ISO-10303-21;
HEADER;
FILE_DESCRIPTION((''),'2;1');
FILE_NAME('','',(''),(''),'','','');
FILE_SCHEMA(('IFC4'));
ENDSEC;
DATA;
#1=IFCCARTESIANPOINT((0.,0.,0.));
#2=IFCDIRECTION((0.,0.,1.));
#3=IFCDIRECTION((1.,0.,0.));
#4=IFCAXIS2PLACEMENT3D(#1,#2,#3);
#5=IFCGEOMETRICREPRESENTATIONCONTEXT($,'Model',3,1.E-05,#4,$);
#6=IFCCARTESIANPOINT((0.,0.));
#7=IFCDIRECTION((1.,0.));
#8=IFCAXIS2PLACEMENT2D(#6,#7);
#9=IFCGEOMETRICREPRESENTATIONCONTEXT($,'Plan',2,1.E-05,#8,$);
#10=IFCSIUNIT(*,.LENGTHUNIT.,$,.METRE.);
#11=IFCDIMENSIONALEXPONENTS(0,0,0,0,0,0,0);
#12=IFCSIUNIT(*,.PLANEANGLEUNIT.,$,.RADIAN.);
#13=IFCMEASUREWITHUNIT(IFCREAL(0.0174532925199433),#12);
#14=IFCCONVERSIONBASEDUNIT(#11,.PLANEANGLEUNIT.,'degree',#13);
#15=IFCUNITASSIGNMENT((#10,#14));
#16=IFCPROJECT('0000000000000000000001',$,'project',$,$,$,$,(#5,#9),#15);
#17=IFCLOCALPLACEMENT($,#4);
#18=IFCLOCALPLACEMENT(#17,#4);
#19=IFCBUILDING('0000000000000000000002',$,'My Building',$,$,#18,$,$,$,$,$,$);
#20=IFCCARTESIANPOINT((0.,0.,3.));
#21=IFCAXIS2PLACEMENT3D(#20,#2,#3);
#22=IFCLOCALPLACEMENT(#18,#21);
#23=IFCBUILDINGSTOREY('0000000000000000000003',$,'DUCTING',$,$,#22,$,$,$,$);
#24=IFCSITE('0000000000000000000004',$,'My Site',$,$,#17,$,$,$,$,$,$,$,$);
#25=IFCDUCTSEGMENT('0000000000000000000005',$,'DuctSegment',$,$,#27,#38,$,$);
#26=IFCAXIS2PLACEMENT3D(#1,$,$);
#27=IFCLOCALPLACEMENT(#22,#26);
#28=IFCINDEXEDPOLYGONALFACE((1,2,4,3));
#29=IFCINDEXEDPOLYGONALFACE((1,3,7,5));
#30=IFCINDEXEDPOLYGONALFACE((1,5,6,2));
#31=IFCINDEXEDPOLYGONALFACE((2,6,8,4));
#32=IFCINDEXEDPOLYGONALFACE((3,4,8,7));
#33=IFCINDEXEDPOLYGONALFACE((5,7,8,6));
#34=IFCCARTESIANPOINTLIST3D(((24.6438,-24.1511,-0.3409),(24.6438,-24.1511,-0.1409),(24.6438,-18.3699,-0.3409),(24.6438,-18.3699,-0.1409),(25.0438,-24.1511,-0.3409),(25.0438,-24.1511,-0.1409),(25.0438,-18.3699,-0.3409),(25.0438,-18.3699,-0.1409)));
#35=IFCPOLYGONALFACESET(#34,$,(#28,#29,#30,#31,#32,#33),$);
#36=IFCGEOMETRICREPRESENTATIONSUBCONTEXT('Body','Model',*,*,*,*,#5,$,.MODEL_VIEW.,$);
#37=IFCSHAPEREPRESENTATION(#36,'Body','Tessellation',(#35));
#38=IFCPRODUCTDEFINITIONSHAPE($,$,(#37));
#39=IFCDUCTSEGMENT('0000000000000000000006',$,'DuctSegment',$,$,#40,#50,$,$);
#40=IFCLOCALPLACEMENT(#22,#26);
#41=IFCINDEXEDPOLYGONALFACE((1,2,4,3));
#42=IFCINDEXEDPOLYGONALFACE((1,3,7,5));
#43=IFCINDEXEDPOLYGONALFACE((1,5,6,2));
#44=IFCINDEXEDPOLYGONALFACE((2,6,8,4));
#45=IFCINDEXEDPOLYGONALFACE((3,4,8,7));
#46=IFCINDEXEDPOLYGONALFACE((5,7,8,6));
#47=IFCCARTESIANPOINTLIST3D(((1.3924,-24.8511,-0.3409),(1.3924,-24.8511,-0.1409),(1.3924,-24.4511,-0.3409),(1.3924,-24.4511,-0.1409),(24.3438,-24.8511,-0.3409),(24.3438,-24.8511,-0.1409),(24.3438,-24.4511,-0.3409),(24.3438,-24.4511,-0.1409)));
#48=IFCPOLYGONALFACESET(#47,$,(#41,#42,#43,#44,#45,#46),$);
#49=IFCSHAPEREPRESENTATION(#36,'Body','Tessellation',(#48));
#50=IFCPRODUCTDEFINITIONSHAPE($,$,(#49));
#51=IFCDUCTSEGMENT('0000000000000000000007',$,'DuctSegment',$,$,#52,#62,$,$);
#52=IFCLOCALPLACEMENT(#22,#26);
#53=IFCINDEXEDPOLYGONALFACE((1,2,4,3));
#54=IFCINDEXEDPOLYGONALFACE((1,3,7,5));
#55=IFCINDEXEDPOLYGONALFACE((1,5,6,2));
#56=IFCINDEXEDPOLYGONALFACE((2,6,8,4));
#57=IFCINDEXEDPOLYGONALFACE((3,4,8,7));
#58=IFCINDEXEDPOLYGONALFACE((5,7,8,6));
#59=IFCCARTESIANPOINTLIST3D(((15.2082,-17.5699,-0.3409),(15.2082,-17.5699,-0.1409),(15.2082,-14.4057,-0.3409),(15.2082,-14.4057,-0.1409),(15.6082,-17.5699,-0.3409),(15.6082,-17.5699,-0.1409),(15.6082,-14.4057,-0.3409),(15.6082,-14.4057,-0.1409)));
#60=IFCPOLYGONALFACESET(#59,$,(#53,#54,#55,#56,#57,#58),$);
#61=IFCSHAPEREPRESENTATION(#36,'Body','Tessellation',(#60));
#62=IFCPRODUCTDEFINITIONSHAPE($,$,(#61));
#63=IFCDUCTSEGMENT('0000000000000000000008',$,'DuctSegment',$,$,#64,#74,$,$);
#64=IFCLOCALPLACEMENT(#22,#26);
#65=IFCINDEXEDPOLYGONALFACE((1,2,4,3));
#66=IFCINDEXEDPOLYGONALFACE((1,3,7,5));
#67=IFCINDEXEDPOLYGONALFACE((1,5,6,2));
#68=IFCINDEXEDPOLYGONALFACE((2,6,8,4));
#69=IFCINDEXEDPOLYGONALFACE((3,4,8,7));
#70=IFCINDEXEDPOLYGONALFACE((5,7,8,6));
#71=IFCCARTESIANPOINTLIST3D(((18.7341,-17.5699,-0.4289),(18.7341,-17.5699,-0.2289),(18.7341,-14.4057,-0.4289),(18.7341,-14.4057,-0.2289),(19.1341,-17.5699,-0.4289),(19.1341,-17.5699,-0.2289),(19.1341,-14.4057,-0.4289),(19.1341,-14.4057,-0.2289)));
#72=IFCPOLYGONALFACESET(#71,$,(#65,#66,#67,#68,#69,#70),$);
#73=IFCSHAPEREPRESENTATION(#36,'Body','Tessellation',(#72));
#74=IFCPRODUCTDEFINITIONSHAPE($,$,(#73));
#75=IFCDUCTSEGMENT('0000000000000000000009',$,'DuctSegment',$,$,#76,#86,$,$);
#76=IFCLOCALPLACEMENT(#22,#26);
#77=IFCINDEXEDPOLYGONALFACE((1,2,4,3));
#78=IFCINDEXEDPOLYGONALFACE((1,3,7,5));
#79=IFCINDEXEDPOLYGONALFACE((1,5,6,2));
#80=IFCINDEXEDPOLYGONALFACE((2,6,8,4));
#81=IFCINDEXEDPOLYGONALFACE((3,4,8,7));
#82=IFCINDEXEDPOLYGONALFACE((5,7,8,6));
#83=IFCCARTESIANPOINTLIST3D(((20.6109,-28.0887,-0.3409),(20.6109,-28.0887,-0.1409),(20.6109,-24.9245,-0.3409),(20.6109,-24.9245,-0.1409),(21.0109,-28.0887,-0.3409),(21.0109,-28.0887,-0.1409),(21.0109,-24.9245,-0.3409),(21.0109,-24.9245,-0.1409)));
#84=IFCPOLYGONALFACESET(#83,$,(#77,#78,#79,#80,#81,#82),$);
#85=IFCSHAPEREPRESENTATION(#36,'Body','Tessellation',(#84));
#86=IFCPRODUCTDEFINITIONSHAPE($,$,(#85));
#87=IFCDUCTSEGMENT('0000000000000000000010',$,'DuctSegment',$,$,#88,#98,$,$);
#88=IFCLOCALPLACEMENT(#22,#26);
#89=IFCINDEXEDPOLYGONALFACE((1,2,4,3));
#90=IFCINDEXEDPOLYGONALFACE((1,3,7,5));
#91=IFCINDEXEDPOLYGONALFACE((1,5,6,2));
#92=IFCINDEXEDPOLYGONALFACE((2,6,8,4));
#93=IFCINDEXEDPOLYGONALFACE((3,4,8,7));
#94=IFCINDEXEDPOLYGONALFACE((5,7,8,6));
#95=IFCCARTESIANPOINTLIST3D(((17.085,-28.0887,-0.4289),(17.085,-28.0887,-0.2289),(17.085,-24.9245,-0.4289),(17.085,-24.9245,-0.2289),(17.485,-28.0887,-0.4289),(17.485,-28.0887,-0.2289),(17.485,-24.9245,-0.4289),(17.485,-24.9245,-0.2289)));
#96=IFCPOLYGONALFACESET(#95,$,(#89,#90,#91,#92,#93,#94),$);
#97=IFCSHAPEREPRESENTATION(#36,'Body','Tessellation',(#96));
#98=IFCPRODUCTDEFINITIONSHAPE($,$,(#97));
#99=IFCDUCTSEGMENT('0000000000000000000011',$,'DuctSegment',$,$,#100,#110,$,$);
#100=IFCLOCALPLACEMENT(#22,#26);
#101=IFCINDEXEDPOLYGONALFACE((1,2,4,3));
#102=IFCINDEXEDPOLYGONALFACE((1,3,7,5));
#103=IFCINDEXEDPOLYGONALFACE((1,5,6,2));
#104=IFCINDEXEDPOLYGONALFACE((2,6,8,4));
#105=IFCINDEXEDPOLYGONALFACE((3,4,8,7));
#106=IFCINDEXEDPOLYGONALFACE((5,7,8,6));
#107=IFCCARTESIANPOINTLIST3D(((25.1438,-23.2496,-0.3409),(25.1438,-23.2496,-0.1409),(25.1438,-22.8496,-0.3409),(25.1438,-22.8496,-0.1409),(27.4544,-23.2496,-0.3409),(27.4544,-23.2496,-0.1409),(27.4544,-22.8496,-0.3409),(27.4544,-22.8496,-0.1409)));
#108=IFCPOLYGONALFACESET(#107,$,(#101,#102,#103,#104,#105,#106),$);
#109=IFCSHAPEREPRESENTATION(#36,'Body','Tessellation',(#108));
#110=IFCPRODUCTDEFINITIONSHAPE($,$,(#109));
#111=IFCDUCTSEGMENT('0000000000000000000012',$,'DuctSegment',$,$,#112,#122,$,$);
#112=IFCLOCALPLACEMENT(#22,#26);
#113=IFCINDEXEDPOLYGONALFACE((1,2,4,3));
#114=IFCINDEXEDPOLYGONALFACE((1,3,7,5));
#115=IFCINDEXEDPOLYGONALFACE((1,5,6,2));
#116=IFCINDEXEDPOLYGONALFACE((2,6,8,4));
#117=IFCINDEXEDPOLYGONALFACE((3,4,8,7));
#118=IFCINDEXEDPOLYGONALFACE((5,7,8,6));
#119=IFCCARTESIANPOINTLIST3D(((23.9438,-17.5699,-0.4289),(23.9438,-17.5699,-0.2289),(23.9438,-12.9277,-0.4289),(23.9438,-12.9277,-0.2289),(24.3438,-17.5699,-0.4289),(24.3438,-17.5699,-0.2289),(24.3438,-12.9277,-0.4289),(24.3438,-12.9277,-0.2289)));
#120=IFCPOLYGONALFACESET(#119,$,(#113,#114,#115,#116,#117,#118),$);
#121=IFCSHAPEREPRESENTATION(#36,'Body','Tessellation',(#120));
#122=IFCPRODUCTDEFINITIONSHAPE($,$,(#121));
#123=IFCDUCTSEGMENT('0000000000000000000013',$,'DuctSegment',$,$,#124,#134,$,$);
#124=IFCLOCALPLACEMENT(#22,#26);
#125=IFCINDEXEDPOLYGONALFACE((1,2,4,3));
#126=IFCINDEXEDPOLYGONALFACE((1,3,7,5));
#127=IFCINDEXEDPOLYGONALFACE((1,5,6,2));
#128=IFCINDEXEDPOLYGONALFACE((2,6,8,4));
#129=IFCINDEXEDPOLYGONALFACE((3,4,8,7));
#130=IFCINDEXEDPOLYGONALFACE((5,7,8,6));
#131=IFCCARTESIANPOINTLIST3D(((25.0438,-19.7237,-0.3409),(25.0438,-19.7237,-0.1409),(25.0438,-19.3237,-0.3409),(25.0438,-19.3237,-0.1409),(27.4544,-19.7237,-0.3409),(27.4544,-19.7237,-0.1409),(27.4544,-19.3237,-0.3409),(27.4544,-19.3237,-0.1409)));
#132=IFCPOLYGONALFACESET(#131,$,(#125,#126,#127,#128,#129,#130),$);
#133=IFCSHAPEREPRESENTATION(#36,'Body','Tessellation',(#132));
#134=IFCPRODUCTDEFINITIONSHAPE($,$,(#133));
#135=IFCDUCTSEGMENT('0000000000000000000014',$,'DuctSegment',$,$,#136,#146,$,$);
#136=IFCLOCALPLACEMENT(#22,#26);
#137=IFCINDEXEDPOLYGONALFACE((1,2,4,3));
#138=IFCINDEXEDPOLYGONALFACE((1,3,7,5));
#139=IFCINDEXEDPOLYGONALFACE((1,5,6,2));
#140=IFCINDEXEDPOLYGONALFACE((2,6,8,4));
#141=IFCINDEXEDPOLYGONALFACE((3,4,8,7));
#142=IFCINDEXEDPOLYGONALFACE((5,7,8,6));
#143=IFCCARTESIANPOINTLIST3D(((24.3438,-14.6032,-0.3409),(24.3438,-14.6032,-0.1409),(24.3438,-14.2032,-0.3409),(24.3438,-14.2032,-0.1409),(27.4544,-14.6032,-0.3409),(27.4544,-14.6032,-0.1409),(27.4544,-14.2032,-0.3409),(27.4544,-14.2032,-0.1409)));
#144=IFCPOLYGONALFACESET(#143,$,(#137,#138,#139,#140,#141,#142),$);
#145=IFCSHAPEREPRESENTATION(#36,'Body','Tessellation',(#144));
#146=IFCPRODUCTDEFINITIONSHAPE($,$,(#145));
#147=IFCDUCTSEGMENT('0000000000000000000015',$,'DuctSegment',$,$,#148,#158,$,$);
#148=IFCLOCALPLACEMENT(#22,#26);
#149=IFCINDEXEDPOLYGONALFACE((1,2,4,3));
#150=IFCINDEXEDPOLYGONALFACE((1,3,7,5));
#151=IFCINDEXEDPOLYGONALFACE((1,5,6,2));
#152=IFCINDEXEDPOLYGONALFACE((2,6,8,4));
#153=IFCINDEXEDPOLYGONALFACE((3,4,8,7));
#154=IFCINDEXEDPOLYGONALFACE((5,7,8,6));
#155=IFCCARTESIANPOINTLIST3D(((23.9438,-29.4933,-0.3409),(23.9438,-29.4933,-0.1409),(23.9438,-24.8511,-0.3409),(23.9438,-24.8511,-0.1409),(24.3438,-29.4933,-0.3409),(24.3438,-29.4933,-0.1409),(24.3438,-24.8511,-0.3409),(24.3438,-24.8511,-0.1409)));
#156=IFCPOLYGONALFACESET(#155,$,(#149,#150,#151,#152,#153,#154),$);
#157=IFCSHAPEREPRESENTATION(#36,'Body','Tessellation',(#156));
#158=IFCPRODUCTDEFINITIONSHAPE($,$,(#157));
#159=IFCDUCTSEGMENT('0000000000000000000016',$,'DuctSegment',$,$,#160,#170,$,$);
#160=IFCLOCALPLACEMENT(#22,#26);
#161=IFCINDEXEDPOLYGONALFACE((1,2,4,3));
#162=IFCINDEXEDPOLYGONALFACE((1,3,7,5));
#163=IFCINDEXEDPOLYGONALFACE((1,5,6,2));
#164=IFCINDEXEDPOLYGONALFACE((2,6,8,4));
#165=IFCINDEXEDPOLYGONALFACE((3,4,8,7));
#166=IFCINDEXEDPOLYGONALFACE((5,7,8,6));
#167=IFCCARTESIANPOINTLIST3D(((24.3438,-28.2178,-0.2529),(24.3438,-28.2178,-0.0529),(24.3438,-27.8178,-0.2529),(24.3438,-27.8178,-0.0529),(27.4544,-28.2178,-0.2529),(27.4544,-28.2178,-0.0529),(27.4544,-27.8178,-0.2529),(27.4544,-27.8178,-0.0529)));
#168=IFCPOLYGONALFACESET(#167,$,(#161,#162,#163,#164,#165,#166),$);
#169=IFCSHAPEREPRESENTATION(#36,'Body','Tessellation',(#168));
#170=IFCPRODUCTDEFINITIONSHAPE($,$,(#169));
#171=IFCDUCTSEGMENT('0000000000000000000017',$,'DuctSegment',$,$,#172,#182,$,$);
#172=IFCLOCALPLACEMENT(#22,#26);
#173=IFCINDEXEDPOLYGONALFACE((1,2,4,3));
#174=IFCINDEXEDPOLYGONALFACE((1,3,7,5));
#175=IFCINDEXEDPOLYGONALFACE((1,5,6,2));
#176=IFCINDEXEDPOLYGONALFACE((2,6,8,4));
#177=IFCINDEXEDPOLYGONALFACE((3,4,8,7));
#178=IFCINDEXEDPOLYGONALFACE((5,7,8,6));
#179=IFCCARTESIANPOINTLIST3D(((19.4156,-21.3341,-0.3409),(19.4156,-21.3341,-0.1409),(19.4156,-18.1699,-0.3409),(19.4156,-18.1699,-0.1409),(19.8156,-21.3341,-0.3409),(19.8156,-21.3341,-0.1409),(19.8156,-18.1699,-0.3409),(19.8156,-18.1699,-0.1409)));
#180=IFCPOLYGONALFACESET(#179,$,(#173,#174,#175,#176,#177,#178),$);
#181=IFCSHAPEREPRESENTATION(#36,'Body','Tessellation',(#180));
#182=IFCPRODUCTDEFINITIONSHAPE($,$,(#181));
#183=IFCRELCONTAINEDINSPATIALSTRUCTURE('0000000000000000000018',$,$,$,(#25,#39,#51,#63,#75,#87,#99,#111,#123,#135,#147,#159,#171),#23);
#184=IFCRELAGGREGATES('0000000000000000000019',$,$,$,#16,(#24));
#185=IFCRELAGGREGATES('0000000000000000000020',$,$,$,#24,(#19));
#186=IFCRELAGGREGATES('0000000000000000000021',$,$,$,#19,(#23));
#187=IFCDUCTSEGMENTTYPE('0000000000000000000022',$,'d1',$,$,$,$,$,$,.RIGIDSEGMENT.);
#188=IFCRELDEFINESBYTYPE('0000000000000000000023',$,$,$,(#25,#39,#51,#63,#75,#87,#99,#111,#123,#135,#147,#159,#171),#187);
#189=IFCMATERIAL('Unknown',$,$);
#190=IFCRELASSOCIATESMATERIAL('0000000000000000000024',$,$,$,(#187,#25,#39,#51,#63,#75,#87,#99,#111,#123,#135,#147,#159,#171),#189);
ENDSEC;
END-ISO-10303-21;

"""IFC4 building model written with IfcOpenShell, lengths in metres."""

from ifc_helpers import new_model, entity, si_unit, converted_unit, frame, origin_with_axes, origin_2d_with_axis, place, context, subcontext, project, spatial, rectangle, extrude, material, material_profile, profile_set, profile_usage, type_object, element, save


model = new_model("IFC4")

# Units and contexts
model_context = context("Model", 3, precision=1e-05, world=origin_with_axes())
plan_context = context("Plan", 2, precision=1e-05, world=origin_2d_with_axis())
body_context = subcontext(model_context, "Body", "Model", "MODEL_VIEW")
ifc_project = project(units=[si_unit("LENGTHUNIT", "METRE"), converted_unit("PLANEANGLEUNIT", "degree", entity("IfcReal", 0.0174532925199433), si_unit("PLANEANGLEUNIT", "RADIAN"), dimensions=[0, 0, 0, 0, 0, 0, 0])], contexts=[model_context, plan_context])

# Site, building, storey
site_placement = place(None, origin_with_axes())
site = spatial("IfcSite", under=ifc_project, at=site_placement, Name="My Site")
building_placement = place(site_placement, origin_with_axes())
building = spatial("IfcBuilding", under=site, at=building_placement, Name="My Building")
storey_placement = place(building_placement, frame((0.0, 0.0, 3.0), z_axis=(0.0, 0.0, 1.0), x_axis=(1.0, 0.0, 0.0)))
storey = spatial("IfcBuildingStorey", under=building, at=storey_placement, Name="DUCTING")

# Duct segments
ifc_material = material(Name="Unknown")
ifc_material_profile_1 = material_profile(ifc_material, rectangle(XDim=0.4, YDim=0.2))
ifc_profile_set_1 = profile_set([ifc_material_profile_1])
ifc_profile_usage_1 = profile_usage(ifc_profile_set_1, cardinal=5)
duct_segment_type = type_object("IfcDuctSegmentType", Name="d1", PredefinedType="RIGIDSEGMENT", material=ifc_profile_set_1)
duct_segment_1_placement = place(storey_placement, frame((24.8438, -18.3699, -0.2409), z_axis=(0.0, -1.0, 0.0), x_axis=(1.0, 0.0, 0.0)))
element("IfcDuctSegment", 1, at=duct_segment_1_placement, inside=storey, type_object=duct_segment_type, material=ifc_profile_usage_1, Name="DuctSegment", context=body_context, shape_type="SweptSolid", body=[
    extrude(rectangle(XDim=0.4, YDim=0.2), origin_with_axes(), (0.0, 0.0, 1.0), 5.7812),
])
ifc_profile_usage_2 = profile_usage(ifc_profile_set_1, cardinal=5)
duct_segment_2_placement = place(storey_placement, frame((24.3438, -24.6511, -0.2409), z_axis=(-1.0, 0.0, 0.0), x_axis=(0.0, -1.0, 0.0)))
element("IfcDuctSegment", 2, at=duct_segment_2_placement, inside=storey, type_object=duct_segment_type, material=ifc_profile_usage_2, Name="DuctSegment", context=body_context, shape_type="SweptSolid", body=[
    extrude(rectangle(XDim=0.4, YDim=0.2), origin_with_axes(), (0.0, 0.0, 1.0), 22.9514),
])
ifc_profile_usage_3 = profile_usage(ifc_profile_set_1, cardinal=5)
duct_segment_3_placement = place(storey_placement, frame((15.4082, -17.5699, -0.2409), z_axis=(0.0, 1.0, 0.0), x_axis=(-1.0, 0.0, 0.0)))
element("IfcDuctSegment", 3, at=duct_segment_3_placement, inside=storey, type_object=duct_segment_type, material=ifc_profile_usage_3, Name="DuctSegment", context=body_context, shape_type="SweptSolid", body=[
    extrude(rectangle(XDim=0.4, YDim=0.2), origin_with_axes(), (0.0, 0.0, 1.0), 3.1642),
])
ifc_profile_usage_4 = profile_usage(ifc_profile_set_1, cardinal=5)
duct_segment_4_placement = place(storey_placement, frame((18.9341, -17.5699, -0.3289), z_axis=(0.0, 1.0, 0.0), x_axis=(-1.0, 0.0, 0.0)))
element("IfcDuctSegment", 4, at=duct_segment_4_placement, inside=storey, type_object=duct_segment_type, material=ifc_profile_usage_4, Name="DuctSegment", context=body_context, shape_type="SweptSolid", body=[
    extrude(rectangle(XDim=0.4, YDim=0.2), origin_with_axes(), (0.0, 0.0, 1.0), 3.1642),
])
ifc_profile_usage_5 = profile_usage(ifc_profile_set_1, cardinal=5)
duct_segment_5_placement = place(storey_placement, frame((20.8109, -24.9245, -0.2409), z_axis=(0.0, -1.0, 0.0), x_axis=(1.0, 0.0, 0.0)))
element("IfcDuctSegment", 5, at=duct_segment_5_placement, inside=storey, type_object=duct_segment_type, material=ifc_profile_usage_5, Name="DuctSegment", context=body_context, shape_type="SweptSolid", body=[
    extrude(rectangle(XDim=0.4, YDim=0.2), origin_with_axes(), (0.0, 0.0, 1.0), 3.1642),
])
ifc_profile_usage_6 = profile_usage(ifc_profile_set_1, cardinal=5)
duct_segment_6_placement = place(storey_placement, frame((17.285, -24.9245, -0.3289), z_axis=(0.0, -1.0, 0.0), x_axis=(1.0, 0.0, 0.0)))
element("IfcDuctSegment", 6, at=duct_segment_6_placement, inside=storey, type_object=duct_segment_type, material=ifc_profile_usage_6, Name="DuctSegment", context=body_context, shape_type="SweptSolid", body=[
    extrude(rectangle(XDim=0.4, YDim=0.2), origin_with_axes(), (0.0, 0.0, 1.0), 3.1642),
])
ifc_profile_usage_7 = profile_usage(ifc_profile_set_1, cardinal=5)
duct_segment_7_placement = place(storey_placement, frame((25.1438, -23.0496, -0.2409), z_axis=(1.0, 0.0, 0.0), x_axis=(0.0, 1.0, 0.0)))
element("IfcDuctSegment", 7, at=duct_segment_7_placement, inside=storey, type_object=duct_segment_type, material=ifc_profile_usage_7, Name="DuctSegment", context=body_context, shape_type="SweptSolid", body=[
    extrude(rectangle(XDim=0.4, YDim=0.2), origin_with_axes(), (0.0, 0.0, 1.0), 2.3106),
])
ifc_profile_usage_8 = profile_usage(ifc_profile_set_1, cardinal=5)
duct_segment_8_placement = place(storey_placement, frame((24.1438, -17.5699, -0.3289), z_axis=(0.0, 1.0, 0.0), x_axis=(-1.0, 0.0, 0.0)))
element("IfcDuctSegment", 8, at=duct_segment_8_placement, inside=storey, type_object=duct_segment_type, material=ifc_profile_usage_8, Name="DuctSegment", context=body_context, shape_type="SweptSolid", body=[
    extrude(rectangle(XDim=0.4, YDim=0.2), origin_with_axes(), (0.0, 0.0, 1.0), 4.6421),
])
ifc_profile_usage_9 = profile_usage(ifc_profile_set_1, cardinal=5)
duct_segment_9_placement = place(storey_placement, frame((25.0438, -19.5237, -0.2409), z_axis=(1.0, 0.0, 0.0), x_axis=(0.0, 1.0, 0.0)))
element("IfcDuctSegment", 9, at=duct_segment_9_placement, inside=storey, type_object=duct_segment_type, material=ifc_profile_usage_9, Name="DuctSegment", context=body_context, shape_type="SweptSolid", body=[
    extrude(rectangle(XDim=0.4, YDim=0.2), origin_with_axes(), (0.0, 0.0, 1.0), 2.4106),
])
ifc_profile_usage_10 = profile_usage(ifc_profile_set_1, cardinal=5)
duct_segment_10_placement = place(storey_placement, frame((24.3438, -14.4032, -0.2409), z_axis=(1.0, 0.0, 0.0), x_axis=(0.0, 1.0, 0.0)))
element("IfcDuctSegment", 10, at=duct_segment_10_placement, inside=storey, type_object=duct_segment_type, material=ifc_profile_usage_10, Name="DuctSegment", context=body_context, shape_type="SweptSolid", body=[
    extrude(rectangle(XDim=0.4, YDim=0.2), origin_with_axes(), (0.0, 0.0, 1.0), 3.1106),
])
ifc_profile_usage_11 = profile_usage(ifc_profile_set_1, cardinal=5)
duct_segment_11_placement = place(storey_placement, frame((24.1438, -24.8511, -0.2409), z_axis=(0.0, -1.0, 0.0), x_axis=(1.0, 0.0, 0.0)))
element("IfcDuctSegment", 11, at=duct_segment_11_placement, inside=storey, type_object=duct_segment_type, material=ifc_profile_usage_11, Name="DuctSegment", context=body_context, shape_type="SweptSolid", body=[
    extrude(rectangle(XDim=0.4, YDim=0.2), origin_with_axes(), (0.0, 0.0, 1.0), 4.6421),
])
ifc_profile_usage_12 = profile_usage(ifc_profile_set_1, cardinal=5)
duct_segment_12_placement = place(storey_placement, frame((24.3438, -28.0178, -0.1529), z_axis=(1.0, -0.000001, 0.0), x_axis=(0.000001, 1.0, 0.0)))
element("IfcDuctSegment", 12, at=duct_segment_12_placement, inside=storey, type_object=duct_segment_type, material=ifc_profile_usage_12, Name="DuctSegment", context=body_context, shape_type="SweptSolid", body=[
    extrude(rectangle(XDim=0.4, YDim=0.2), origin_with_axes(), (0.0, 0.0, 1.0), 3.1106),
])
ifc_profile_usage_13 = profile_usage(ifc_profile_set_1, cardinal=5)
duct_segment_13_placement = place(storey_placement, frame((19.6156, -18.1699, -0.2409), z_axis=(0.0, -1.0, 0.0), x_axis=(1.0, 0.0, 0.0)))
element("IfcDuctSegment", 13, at=duct_segment_13_placement, inside=storey, type_object=duct_segment_type, material=ifc_profile_usage_13, Name="DuctSegment", context=body_context, shape_type="SweptSolid", body=[
    extrude(rectangle(XDim=0.4, YDim=0.2), origin_with_axes(), (0.0, 0.0, 1.0), 3.1642),
])

save(model, "model.ifc")
